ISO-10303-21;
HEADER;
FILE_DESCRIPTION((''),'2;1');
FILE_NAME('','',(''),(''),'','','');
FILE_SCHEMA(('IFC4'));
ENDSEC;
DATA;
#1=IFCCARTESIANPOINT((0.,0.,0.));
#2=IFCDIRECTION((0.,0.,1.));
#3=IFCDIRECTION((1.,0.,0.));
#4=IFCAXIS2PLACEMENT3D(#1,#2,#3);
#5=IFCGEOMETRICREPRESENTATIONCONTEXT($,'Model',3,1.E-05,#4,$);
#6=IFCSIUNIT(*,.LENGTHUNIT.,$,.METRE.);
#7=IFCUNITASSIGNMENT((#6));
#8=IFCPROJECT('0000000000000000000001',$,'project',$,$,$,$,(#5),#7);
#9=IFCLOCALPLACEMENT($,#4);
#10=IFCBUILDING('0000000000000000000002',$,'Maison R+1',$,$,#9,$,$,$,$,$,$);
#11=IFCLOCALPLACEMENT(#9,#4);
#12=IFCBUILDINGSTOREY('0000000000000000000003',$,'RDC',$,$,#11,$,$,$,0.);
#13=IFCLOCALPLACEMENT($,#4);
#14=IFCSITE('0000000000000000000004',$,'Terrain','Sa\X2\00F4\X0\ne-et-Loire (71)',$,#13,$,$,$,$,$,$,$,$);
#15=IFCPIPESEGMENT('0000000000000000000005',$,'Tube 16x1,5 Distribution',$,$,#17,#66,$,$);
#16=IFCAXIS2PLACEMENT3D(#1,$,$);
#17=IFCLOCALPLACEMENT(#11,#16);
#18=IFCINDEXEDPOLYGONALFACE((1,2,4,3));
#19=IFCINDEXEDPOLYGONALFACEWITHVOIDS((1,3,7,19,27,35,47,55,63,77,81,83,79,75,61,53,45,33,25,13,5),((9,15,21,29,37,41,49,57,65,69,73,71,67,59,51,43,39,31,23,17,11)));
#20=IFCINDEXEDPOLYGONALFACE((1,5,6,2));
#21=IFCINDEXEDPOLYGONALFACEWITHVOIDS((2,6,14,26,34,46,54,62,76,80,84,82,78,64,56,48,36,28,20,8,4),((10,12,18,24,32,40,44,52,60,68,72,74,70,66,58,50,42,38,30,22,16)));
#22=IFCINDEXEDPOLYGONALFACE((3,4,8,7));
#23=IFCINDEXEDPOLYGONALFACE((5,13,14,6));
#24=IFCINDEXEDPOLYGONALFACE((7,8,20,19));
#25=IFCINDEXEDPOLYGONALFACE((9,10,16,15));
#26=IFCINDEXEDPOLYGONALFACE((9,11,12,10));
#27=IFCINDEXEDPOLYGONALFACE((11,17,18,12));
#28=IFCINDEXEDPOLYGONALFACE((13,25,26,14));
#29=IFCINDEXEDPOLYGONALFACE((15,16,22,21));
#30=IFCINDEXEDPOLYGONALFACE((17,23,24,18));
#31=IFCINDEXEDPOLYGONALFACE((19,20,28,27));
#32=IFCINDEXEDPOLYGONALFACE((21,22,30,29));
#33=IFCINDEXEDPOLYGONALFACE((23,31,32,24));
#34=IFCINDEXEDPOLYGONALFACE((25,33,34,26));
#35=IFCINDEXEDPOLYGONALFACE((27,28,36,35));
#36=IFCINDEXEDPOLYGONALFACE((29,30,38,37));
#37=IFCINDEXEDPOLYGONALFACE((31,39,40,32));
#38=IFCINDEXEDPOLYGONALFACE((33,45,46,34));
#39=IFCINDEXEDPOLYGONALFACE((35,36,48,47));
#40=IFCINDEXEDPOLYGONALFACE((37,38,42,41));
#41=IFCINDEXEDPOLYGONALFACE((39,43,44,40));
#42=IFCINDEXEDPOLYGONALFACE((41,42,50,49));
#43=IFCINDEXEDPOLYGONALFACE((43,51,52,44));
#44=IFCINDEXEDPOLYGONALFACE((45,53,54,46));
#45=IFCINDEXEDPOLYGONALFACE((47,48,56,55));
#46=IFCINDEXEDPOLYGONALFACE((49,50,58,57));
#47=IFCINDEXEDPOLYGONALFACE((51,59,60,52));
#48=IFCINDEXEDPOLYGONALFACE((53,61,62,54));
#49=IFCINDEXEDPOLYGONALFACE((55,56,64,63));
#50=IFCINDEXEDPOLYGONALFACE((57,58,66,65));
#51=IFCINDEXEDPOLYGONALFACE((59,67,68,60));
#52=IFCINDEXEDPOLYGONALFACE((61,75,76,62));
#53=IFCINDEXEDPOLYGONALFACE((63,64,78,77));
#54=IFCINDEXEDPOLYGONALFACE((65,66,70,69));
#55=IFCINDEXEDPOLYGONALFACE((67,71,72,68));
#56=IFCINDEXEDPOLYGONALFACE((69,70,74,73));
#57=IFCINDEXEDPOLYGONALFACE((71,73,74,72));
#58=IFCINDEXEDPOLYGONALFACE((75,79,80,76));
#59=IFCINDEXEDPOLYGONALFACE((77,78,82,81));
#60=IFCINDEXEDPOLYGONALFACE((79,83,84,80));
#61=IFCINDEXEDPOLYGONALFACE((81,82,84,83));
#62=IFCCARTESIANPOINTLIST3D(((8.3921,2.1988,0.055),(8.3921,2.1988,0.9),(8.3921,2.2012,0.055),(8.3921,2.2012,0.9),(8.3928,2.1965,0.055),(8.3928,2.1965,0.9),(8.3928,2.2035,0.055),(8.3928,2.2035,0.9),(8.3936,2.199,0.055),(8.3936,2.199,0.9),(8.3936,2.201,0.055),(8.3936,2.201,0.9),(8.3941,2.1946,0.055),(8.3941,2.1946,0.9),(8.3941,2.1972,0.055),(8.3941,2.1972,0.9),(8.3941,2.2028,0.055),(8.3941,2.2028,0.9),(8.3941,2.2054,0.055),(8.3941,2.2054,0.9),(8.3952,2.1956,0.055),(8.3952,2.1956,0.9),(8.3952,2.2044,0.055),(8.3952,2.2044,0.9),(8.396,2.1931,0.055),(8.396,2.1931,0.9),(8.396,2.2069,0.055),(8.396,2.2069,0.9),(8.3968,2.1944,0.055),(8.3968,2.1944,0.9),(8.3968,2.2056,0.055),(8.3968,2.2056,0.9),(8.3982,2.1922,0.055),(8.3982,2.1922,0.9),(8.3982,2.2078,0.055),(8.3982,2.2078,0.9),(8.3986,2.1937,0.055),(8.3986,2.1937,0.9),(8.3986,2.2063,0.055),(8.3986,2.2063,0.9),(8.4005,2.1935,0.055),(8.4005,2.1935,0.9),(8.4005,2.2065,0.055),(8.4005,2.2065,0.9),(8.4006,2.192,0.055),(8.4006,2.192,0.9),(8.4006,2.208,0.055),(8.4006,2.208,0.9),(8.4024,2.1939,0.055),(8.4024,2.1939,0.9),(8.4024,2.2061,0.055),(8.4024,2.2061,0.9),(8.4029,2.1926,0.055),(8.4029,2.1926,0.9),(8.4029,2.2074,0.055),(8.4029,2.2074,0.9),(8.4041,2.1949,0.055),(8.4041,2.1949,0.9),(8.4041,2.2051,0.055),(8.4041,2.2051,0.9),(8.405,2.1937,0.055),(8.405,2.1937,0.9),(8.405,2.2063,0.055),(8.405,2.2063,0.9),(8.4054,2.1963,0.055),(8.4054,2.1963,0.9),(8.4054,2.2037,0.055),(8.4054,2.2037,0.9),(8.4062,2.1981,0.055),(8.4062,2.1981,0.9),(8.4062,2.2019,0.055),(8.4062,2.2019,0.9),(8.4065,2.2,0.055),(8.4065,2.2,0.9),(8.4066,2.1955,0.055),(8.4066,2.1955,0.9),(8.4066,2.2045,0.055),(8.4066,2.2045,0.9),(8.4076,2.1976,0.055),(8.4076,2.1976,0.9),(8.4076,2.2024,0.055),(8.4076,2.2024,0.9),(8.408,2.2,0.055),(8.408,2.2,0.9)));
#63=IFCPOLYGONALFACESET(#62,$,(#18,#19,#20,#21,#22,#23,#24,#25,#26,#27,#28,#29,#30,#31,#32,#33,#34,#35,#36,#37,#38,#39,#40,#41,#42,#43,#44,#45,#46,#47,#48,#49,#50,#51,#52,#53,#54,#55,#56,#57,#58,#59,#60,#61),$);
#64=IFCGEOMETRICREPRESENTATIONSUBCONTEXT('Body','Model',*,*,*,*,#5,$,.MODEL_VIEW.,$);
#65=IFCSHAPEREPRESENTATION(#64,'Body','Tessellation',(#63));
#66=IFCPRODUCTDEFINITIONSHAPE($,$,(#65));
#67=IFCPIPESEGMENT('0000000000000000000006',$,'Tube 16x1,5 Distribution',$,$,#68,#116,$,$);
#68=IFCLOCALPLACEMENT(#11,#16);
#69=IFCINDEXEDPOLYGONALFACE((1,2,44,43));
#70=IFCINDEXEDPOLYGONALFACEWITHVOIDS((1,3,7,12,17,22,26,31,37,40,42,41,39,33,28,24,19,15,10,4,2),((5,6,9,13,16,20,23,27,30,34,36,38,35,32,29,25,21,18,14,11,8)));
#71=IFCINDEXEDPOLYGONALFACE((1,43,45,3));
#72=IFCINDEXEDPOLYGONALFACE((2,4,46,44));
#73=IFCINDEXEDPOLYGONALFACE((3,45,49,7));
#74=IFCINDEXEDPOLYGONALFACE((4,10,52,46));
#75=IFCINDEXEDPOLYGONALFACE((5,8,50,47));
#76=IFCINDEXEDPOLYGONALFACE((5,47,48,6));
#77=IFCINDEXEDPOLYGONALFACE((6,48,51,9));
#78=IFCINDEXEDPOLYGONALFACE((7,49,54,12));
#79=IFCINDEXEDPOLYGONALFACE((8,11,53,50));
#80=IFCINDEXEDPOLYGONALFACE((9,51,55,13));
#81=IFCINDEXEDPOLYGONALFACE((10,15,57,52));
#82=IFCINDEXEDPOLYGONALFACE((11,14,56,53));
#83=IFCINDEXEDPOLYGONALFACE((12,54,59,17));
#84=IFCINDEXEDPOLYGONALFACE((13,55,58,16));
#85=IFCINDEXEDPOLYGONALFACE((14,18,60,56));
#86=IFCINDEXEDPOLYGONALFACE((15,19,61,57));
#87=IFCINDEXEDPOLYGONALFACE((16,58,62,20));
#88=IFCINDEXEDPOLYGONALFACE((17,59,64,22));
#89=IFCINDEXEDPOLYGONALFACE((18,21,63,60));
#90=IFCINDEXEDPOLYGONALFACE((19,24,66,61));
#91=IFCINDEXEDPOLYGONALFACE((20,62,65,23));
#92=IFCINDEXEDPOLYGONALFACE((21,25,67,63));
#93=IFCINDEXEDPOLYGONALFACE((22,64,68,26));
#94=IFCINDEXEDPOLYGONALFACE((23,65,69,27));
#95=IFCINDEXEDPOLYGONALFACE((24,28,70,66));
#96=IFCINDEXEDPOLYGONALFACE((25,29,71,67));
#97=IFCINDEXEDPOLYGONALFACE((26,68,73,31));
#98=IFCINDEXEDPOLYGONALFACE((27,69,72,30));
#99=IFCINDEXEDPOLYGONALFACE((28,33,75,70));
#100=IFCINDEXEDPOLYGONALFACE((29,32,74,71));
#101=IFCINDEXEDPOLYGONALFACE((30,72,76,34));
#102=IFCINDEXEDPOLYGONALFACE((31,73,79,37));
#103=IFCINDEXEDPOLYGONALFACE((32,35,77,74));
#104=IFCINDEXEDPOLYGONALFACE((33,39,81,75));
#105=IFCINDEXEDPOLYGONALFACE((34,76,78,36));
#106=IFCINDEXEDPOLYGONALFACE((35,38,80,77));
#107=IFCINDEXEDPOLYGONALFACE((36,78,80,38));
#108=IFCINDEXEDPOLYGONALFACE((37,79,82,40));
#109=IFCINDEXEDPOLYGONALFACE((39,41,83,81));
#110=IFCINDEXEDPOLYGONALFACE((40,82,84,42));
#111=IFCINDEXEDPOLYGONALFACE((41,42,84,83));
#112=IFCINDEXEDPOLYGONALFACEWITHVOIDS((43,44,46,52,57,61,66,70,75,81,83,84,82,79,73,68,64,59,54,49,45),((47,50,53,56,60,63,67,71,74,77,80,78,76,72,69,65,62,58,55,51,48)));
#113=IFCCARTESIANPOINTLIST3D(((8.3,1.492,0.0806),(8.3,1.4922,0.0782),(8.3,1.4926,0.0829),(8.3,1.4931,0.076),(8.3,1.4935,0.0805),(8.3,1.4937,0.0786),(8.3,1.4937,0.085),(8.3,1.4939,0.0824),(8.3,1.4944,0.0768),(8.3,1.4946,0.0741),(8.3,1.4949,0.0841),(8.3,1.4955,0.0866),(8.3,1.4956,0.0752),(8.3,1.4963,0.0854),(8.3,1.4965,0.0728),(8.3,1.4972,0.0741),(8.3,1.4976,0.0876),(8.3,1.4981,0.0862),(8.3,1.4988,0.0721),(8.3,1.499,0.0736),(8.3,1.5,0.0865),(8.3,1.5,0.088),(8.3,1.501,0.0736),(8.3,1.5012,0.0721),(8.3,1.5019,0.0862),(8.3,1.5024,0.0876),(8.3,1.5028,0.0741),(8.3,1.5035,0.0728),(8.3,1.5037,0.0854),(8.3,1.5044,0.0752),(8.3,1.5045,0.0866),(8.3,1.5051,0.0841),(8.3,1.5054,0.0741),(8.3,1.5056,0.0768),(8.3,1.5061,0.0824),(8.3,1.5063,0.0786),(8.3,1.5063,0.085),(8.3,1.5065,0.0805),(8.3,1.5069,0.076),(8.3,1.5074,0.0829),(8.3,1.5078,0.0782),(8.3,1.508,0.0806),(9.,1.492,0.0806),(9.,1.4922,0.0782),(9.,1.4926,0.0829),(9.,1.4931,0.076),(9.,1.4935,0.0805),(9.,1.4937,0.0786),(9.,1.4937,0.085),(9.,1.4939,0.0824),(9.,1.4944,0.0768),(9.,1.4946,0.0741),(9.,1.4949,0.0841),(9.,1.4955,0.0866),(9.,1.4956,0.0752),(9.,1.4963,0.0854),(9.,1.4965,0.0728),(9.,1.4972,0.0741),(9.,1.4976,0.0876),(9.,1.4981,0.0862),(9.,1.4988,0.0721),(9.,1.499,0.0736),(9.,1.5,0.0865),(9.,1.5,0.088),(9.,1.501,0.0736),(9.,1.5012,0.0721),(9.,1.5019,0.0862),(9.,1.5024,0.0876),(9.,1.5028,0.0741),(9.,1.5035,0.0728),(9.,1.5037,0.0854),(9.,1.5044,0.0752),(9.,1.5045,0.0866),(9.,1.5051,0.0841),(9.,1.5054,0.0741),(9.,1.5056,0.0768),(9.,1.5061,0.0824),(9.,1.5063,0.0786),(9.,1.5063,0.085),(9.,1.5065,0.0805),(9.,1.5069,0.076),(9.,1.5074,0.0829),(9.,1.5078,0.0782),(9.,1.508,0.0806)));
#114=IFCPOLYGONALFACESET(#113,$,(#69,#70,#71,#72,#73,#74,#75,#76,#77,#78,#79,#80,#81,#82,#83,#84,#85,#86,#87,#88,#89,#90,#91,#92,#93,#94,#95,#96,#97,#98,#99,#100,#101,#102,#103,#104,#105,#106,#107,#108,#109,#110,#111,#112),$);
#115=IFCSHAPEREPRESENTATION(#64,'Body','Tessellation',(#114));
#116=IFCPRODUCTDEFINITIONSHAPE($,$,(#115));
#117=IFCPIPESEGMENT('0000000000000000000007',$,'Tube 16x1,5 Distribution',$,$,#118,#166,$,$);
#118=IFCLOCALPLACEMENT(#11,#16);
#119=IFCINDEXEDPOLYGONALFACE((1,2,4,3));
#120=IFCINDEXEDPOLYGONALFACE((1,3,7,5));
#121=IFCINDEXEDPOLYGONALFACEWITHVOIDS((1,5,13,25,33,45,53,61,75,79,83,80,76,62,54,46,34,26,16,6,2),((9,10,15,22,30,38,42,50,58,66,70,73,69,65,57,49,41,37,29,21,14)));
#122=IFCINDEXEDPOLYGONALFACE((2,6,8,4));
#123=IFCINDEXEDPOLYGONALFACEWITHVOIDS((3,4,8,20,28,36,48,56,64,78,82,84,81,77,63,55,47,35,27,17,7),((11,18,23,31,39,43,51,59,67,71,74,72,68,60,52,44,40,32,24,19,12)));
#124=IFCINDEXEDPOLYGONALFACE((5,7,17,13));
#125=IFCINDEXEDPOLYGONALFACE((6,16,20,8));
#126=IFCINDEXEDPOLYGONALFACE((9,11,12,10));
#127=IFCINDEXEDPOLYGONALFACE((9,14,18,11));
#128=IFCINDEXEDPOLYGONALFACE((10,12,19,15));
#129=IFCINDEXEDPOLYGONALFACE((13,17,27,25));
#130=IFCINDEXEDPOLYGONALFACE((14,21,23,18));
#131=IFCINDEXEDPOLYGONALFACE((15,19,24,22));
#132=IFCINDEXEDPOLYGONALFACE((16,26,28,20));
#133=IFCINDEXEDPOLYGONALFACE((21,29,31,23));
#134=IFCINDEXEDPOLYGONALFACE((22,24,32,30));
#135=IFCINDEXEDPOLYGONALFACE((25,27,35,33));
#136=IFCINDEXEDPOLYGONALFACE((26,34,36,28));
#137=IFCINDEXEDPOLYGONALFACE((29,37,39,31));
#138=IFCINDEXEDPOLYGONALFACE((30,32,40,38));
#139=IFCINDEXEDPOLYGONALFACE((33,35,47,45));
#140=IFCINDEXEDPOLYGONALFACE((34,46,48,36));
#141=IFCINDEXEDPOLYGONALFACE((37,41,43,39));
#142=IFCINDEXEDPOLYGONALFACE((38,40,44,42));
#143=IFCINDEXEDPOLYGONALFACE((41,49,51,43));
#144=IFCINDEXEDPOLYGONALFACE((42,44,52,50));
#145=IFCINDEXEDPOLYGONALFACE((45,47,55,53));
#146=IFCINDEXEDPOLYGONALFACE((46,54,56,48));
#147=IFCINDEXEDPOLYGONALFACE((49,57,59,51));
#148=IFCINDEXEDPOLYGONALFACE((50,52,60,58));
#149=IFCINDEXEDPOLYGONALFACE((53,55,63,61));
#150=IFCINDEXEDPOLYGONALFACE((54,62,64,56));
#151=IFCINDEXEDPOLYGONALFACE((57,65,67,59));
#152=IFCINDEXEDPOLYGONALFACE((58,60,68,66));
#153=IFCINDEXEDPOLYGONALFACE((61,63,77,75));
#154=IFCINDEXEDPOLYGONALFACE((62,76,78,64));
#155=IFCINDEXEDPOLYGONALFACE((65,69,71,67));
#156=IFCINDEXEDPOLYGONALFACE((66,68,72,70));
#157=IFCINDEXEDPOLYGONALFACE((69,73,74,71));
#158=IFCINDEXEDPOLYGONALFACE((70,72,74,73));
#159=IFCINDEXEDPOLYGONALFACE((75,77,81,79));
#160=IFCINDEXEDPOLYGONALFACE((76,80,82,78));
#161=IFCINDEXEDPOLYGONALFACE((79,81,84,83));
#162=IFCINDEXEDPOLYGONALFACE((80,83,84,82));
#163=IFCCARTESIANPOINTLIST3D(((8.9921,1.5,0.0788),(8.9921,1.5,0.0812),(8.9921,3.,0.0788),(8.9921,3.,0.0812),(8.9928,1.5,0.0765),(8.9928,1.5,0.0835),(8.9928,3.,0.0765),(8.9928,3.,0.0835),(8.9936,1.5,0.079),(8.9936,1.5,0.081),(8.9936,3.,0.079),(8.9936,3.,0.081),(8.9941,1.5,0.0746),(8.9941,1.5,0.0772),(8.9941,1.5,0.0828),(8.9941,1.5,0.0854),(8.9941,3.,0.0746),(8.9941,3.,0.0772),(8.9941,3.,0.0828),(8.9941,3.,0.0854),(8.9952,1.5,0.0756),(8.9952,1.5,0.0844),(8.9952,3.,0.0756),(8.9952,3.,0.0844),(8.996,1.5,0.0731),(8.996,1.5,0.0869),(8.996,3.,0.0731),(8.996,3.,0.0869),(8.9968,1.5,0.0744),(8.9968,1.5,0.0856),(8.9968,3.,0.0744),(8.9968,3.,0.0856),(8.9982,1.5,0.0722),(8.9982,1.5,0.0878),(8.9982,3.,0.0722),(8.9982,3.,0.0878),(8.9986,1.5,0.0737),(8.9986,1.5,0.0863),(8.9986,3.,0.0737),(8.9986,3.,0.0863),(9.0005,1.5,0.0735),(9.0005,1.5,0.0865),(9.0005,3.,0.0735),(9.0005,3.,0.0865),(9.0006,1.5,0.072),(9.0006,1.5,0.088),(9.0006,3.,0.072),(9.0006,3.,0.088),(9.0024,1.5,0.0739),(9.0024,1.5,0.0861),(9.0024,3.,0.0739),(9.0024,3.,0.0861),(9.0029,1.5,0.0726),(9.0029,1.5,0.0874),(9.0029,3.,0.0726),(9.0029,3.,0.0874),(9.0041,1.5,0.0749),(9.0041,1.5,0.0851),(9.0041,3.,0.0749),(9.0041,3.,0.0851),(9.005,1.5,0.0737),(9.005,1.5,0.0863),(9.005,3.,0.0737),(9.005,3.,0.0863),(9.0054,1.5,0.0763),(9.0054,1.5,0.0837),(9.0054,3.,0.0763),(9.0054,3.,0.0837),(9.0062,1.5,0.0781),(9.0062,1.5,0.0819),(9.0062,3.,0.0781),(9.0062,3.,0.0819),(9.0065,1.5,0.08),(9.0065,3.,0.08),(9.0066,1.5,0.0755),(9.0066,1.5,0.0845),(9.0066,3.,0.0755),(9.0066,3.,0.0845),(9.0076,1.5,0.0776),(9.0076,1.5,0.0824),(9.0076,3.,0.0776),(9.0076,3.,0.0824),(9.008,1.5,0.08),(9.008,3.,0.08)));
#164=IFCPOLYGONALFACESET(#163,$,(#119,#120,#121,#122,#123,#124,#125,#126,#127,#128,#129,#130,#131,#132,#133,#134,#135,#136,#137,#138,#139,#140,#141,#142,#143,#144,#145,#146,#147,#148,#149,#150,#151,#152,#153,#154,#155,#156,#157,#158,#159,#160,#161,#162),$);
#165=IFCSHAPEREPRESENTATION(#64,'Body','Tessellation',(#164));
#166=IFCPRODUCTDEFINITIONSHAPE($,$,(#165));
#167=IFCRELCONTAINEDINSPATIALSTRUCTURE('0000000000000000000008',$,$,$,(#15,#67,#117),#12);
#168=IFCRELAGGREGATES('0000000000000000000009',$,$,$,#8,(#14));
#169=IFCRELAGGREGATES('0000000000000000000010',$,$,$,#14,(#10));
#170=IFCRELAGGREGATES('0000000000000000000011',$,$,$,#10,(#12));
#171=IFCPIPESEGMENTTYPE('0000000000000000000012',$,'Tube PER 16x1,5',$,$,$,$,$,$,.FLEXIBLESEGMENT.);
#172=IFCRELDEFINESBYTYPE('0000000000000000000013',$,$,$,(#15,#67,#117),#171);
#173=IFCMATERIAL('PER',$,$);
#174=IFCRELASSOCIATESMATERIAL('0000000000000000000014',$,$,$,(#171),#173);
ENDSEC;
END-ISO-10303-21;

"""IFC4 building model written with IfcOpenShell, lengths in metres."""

from ifc_helpers import new_model, si_unit, frame, origin_with_axes, place, context, subcontext, project, spatial, hollow_circle, extrude, material, type_object, element, save


model = new_model("IFC4")

# Units and contexts
model_context = context("Model", 3, precision=1e-05, world=origin_with_axes())
body_context = subcontext(model_context, "Body", "Model", "MODEL_VIEW")
ifc_project = project(units=[si_unit("LENGTHUNIT", "METRE")], contexts=[model_context])

# Site, building, storey
site_placement = place(None, origin_with_axes())
site = spatial("IfcSite", under=ifc_project, at=site_placement, Name="Terrain", Description="Saône-et-Loire (71)")
building_placement = place(None, origin_with_axes())
building = spatial("IfcBuilding", under=site, at=building_placement, Name="Maison R+1")
storey_placement = place(building_placement, origin_with_axes())
storey = spatial("IfcBuildingStorey", under=building, at=storey_placement, Name="RDC", Elevation=0.0)

# Pipe segments
ifc_material_1 = material(Name="PER")
pipe_segment_type_1 = type_object("IfcPipeSegmentType", Name="Tube PER 16x1,5", PredefinedType="FLEXIBLESEGMENT", material=ifc_material_1)
pipe_segment_1_placement = place(storey_placement, frame((8.4, 2.2, 0.055), z_axis=(0.0, 0.0, 1.0), x_axis=(1.0, 0.0, 0.0)))
element("IfcPipeSegment", 1, at=pipe_segment_1_placement, inside=storey, type_object=pipe_segment_type_1, Name="Tube 16x1,5 Distribution", context=body_context, shape_type="SweptSolid", body=[
    extrude(hollow_circle(Radius=0.008, WallThickness=0.0015), origin_with_axes(), (0.0, 0.0, 1.0), 0.845),
])
pipe_segment_2_placement = place(storey_placement, frame((8.3, 1.5, 0.08), z_axis=(1.0, 0.0, 0.0), x_axis=(0.0, 0.0, 1.0)))
element("IfcPipeSegment", 2, at=pipe_segment_2_placement, inside=storey, type_object=pipe_segment_type_1, Name="Tube 16x1,5 Distribution", context=body_context, shape_type="SweptSolid", body=[
    extrude(hollow_circle(Radius=0.008, WallThickness=0.0015), origin_with_axes(), (0.0, 0.0, 1.0), 0.7),
])
pipe_segment_3_placement = place(storey_placement, frame((9.0, 1.5, 0.08), z_axis=(0.0, 1.0, 0.0), x_axis=(1.0, 0.0, 0.0)))
element("IfcPipeSegment", 3, at=pipe_segment_3_placement, inside=storey, type_object=pipe_segment_type_1, Name="Tube 16x1,5 Distribution", context=body_context, shape_type="SweptSolid", body=[
    extrude(hollow_circle(Radius=0.008, WallThickness=0.0015), origin_with_axes(), (0.0, 0.0, 1.0), 1.5),
])

save(model, "model.ifc")
